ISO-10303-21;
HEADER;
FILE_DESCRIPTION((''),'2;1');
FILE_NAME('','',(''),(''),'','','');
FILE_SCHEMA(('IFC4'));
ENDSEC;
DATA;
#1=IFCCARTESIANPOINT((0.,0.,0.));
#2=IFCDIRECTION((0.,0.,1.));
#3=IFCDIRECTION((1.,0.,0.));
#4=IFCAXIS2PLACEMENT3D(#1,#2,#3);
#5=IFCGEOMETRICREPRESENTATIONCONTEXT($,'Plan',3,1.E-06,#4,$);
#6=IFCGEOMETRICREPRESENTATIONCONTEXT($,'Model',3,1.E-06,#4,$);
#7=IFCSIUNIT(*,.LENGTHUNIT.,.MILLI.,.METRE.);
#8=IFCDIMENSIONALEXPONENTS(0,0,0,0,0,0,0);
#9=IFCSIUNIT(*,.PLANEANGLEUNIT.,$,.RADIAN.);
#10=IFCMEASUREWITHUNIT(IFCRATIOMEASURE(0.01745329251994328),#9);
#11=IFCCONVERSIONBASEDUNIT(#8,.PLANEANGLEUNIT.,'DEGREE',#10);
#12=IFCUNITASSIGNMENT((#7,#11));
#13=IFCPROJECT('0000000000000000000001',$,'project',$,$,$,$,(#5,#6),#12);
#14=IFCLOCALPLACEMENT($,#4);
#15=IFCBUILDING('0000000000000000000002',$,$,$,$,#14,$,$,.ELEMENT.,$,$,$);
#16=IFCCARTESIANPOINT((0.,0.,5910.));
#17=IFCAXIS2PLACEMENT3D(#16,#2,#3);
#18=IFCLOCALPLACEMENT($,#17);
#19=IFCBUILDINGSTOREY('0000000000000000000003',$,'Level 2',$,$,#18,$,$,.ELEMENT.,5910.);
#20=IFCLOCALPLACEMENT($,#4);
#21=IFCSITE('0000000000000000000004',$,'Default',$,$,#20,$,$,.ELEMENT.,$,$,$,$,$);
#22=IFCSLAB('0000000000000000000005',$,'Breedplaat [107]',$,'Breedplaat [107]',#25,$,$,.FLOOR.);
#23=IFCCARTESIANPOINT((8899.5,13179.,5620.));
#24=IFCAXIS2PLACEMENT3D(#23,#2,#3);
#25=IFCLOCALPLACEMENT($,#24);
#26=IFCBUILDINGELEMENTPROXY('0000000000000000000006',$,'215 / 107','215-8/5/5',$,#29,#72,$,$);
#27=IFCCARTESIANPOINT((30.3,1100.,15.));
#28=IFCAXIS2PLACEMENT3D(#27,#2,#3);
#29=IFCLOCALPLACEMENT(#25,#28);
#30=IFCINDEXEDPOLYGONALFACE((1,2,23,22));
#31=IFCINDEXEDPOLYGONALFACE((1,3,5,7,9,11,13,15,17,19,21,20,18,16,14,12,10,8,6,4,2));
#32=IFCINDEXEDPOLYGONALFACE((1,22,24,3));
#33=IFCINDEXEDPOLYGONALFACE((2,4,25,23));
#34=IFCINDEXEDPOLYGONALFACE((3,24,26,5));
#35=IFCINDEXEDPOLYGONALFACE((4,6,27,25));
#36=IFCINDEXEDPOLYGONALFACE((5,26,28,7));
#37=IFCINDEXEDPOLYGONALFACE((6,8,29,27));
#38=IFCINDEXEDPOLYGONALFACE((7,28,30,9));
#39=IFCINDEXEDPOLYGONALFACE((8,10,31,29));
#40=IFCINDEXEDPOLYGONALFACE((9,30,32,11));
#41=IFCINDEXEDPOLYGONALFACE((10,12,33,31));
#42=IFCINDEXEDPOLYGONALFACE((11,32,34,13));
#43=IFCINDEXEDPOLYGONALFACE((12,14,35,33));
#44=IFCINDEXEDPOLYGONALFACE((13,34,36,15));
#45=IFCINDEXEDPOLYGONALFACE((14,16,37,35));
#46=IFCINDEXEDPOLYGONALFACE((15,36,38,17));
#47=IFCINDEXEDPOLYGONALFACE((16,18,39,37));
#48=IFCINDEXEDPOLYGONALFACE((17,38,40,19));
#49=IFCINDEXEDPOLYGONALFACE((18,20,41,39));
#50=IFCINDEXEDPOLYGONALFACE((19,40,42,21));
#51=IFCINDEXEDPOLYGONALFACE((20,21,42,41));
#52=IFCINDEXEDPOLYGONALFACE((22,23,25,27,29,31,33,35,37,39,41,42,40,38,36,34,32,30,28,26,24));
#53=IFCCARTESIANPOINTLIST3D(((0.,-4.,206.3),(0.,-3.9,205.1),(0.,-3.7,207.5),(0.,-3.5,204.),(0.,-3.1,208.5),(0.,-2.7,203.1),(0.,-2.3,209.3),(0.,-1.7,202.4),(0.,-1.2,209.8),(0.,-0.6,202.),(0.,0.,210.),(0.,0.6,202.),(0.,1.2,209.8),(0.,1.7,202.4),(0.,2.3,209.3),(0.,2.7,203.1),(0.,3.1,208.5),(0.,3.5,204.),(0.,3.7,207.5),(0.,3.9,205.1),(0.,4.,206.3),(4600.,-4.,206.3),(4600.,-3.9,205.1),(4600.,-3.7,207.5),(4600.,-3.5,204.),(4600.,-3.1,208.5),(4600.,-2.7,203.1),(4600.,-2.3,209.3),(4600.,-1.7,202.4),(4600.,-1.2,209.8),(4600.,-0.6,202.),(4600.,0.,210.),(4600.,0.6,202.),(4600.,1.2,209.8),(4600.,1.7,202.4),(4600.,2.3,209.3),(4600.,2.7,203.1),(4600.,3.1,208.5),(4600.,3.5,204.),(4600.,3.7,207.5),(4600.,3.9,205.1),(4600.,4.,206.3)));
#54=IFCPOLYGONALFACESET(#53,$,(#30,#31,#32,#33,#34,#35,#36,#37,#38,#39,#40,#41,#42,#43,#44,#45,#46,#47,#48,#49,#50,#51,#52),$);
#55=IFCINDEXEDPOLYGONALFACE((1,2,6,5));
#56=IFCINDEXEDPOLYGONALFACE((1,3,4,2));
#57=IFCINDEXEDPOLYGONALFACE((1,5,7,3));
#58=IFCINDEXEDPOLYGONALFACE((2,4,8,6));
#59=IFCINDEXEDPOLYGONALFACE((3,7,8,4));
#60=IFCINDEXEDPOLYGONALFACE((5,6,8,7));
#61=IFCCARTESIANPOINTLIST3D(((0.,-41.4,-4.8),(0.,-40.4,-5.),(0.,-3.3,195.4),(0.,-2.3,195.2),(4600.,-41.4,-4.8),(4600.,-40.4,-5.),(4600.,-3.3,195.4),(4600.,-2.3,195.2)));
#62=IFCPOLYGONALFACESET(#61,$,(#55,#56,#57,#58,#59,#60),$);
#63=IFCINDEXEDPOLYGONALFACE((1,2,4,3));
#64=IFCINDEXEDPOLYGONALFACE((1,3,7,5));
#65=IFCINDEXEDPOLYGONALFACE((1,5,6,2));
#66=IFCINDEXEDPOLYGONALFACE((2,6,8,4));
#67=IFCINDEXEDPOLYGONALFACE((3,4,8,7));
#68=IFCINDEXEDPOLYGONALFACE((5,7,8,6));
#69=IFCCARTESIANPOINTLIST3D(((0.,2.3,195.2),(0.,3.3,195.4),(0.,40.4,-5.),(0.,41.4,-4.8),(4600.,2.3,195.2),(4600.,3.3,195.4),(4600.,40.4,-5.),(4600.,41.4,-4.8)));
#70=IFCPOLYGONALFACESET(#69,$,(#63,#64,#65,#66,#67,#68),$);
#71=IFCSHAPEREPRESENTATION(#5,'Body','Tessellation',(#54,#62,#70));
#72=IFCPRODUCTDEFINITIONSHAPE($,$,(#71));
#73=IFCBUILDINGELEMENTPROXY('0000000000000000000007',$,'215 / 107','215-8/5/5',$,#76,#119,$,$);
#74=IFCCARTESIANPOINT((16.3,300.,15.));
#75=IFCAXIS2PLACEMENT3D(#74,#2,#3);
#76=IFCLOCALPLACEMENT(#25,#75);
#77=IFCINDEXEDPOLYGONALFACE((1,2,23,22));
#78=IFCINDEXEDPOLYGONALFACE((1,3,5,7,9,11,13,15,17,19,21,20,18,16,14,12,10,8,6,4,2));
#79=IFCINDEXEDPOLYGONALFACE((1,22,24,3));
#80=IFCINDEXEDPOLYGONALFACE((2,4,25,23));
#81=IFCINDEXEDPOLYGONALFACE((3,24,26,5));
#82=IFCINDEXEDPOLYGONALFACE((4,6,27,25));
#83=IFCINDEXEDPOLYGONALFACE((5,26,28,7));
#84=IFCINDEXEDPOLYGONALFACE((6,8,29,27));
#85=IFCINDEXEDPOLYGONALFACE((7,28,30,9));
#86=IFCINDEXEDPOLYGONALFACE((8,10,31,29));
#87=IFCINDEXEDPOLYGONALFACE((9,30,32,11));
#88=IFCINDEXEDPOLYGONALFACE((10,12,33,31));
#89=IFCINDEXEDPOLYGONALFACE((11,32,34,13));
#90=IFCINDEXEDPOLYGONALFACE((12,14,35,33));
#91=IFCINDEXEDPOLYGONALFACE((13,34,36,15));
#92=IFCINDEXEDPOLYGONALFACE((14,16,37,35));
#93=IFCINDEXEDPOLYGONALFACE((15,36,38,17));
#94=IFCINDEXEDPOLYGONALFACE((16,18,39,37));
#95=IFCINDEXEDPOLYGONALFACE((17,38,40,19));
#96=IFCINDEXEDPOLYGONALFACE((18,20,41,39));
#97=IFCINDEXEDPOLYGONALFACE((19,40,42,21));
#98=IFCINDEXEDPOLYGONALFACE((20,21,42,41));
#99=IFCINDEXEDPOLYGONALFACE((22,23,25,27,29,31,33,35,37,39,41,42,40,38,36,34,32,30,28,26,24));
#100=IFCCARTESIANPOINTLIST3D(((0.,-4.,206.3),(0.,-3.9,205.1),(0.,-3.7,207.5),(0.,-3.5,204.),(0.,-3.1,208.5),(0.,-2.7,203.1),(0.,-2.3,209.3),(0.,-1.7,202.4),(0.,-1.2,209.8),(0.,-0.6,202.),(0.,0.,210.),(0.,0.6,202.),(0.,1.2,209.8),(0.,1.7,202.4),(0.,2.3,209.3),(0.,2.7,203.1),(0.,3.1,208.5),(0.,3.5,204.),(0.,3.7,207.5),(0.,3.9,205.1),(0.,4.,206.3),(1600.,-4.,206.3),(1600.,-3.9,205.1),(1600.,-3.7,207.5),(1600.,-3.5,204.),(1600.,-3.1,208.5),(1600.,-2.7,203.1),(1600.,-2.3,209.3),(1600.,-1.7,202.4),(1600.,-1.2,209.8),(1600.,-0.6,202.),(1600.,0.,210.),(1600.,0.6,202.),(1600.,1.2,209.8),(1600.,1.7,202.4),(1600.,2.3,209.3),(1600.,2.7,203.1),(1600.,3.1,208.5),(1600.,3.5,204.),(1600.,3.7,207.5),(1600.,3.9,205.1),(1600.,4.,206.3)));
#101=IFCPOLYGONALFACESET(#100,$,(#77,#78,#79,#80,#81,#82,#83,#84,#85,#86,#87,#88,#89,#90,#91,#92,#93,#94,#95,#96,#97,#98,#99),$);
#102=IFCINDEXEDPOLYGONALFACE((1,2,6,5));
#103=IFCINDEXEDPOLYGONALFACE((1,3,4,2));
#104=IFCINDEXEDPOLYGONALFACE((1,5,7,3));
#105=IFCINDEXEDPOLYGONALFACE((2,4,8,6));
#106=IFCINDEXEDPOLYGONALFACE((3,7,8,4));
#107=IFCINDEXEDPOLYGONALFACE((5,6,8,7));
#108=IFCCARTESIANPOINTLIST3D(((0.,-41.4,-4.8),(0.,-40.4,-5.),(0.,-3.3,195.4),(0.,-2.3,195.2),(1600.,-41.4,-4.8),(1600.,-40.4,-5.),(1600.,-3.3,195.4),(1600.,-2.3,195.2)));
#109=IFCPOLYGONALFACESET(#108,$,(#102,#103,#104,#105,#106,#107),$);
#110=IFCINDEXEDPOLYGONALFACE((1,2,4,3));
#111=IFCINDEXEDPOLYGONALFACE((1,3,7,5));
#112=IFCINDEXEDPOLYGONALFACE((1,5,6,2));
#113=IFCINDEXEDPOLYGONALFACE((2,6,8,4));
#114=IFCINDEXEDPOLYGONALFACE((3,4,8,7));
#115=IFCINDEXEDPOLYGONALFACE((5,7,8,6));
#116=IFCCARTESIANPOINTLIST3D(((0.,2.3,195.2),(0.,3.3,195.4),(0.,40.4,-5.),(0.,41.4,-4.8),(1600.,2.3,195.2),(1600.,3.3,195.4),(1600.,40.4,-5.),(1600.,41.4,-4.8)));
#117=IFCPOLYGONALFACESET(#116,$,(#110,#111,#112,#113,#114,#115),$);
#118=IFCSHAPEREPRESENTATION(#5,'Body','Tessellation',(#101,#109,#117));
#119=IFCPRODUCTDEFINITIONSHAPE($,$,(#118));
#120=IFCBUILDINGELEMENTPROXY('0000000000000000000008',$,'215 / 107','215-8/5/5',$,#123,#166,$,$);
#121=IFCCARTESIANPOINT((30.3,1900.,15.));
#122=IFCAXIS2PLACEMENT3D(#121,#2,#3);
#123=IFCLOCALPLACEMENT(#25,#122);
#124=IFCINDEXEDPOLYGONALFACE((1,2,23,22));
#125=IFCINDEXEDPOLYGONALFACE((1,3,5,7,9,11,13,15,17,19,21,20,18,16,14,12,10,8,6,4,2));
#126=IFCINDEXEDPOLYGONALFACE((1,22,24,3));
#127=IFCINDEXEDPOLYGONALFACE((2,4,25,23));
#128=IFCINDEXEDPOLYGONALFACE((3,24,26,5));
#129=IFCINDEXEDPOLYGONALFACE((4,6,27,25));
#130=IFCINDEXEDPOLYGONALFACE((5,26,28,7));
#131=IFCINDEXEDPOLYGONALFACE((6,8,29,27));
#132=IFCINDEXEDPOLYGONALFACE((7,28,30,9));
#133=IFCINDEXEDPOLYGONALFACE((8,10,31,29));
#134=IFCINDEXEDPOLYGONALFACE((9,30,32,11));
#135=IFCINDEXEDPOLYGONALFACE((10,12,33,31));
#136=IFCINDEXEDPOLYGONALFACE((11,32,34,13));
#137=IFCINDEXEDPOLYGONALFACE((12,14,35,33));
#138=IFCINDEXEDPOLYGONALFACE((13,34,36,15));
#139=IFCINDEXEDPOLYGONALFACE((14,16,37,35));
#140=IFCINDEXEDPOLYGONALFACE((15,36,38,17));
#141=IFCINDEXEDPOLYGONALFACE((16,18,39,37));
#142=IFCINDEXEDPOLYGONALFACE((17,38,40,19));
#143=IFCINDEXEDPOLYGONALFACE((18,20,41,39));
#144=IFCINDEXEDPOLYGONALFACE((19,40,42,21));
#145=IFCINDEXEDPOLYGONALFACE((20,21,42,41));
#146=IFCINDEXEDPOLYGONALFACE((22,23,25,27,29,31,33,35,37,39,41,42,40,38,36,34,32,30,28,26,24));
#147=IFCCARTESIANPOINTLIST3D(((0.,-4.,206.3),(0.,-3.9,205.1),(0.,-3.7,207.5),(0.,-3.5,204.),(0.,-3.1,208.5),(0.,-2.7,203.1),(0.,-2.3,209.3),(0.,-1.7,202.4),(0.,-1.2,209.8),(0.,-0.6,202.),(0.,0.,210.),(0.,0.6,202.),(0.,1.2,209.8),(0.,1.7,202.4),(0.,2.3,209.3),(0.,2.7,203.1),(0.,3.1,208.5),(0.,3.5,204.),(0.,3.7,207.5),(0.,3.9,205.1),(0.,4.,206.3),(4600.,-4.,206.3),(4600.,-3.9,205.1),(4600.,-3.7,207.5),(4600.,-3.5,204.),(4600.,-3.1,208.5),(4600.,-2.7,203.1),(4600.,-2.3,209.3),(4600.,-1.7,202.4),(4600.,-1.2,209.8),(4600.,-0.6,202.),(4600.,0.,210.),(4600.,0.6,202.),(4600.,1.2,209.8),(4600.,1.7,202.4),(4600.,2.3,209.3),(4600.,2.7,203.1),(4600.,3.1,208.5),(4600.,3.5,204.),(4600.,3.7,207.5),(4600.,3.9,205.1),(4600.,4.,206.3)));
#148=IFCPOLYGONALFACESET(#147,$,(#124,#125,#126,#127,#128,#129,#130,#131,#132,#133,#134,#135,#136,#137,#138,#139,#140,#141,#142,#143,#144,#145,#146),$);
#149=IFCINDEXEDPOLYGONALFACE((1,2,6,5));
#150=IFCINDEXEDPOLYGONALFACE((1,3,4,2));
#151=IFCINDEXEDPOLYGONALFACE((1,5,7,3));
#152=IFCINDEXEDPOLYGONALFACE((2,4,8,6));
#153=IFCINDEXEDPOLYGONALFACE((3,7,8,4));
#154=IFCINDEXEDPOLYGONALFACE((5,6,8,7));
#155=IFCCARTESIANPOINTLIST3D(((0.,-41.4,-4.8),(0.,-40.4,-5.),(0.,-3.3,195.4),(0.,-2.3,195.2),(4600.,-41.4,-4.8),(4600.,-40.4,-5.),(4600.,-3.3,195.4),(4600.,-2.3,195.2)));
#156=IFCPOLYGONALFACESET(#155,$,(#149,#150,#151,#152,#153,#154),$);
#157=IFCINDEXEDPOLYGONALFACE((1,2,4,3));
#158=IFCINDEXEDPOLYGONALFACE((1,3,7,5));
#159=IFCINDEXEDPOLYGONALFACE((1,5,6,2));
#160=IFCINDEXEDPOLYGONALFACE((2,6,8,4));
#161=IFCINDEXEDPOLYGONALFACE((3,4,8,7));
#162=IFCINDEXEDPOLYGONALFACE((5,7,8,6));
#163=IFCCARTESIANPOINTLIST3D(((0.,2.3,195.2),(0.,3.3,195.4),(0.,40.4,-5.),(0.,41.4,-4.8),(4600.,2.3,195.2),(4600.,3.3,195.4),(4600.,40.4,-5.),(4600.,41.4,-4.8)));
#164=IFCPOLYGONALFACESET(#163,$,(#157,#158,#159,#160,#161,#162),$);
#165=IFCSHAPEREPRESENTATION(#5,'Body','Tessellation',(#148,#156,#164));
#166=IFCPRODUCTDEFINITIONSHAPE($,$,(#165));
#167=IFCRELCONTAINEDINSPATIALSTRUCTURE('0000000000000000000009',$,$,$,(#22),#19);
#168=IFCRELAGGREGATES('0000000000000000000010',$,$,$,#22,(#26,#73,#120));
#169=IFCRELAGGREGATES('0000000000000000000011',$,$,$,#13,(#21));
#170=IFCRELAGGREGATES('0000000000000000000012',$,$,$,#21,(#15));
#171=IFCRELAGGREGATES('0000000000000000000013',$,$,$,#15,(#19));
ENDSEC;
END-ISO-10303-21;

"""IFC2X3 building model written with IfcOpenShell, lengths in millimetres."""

from ifc_helpers import new_model, entity, si_unit, converted_unit, frame, origin_with_axes, origin_2d_with_axis, place, context, project, spatial, rectangle, circle, extrude, element, aggregate, save


model = new_model("IFC2X3")

# Units and contexts
plan_context = context("Plan", 3, precision=1e-06, world=origin_with_axes())
model_context = context("Model", 3, precision=1e-06, world=origin_with_axes())
ifc_project = project(units=[si_unit("LENGTHUNIT", "METRE", prefix="MILLI"), converted_unit("PLANEANGLEUNIT", "DEGREE", entity("IfcRatioMeasure", 0.01745329251994328), si_unit("PLANEANGLEUNIT", "RADIAN"), dimensions=[0, 0, 0, 0, 0, 0, 0])], contexts=[plan_context, model_context])

# Site, building, storey
site_placement = place(None, origin_with_axes())
site = spatial("IfcSite", under=ifc_project, at=site_placement, Name="Default", CompositionType="ELEMENT")
building_placement = place(None, origin_with_axes())
building = spatial("IfcBuilding", under=site, at=building_placement, CompositionType="ELEMENT")
storey_placement = place(None, frame((0.0, 0.0, 5910.0), z_axis=(0.0, 0.0, 1.0), x_axis=(1.0, 0.0, 0.0)))
storey = spatial("IfcBuildingStorey", under=building, at=storey_placement, Name="Level 2", CompositionType="ELEMENT", Elevation=5910.0)

# Slab, building element proxies
slab_1_placement = place(None, frame((8899.5, 13179.0, 5620.0), z_axis=(0.0, 0.0, 1.0), x_axis=(1.0, 0.0, 0.0)))
slab_1 = element("IfcSlab", 1, at=slab_1_placement, inside=storey, Name="Breedplaat [107]", ObjectType="Breedplaat [107]", PredefinedType="FLOOR")
proxy_1_placement = place(slab_1_placement, frame((30.3, 1100.0, 15.0), z_axis=(0.0, 0.0, 1.0), x_axis=(1.0, 0.0, 0.0)))
proxy_1 = element("IfcBuildingElementProxy", 2, at=proxy_1_placement, Name="215 / 107", Description="215-8/5/5", context=plan_context, shape_type="SweptSolid", body=[
    extrude(circle(Radius=4.0, at=origin_2d_with_axis()), frame((0.0, 0.0, 206.0), z_axis=(1.0, 0.0, 0.0), x_axis=(0.0, 0.0, 1.0)), (0.0, 0.0, 1.0), 4600.0),
    extrude(rectangle(XDim=203.8, YDim=1.0, at=origin_2d_with_axis()), frame((0.0, -21.9, 95.2), z_axis=(1.0, 0.0, 0.0), x_axis=(0.0, 0.187112, 0.982339)), (0.0, 0.0, 1.0), 4600.0),
    extrude(rectangle(XDim=203.8, YDim=1.0, at=origin_2d_with_axis()), frame((0.0, 21.9, 95.2), z_axis=(1.0, 0.0, 0.0), x_axis=(0.0, -0.187112, 0.982339)), (0.0, 0.0, 1.0), 4600.0),
])
proxy_2_placement = place(slab_1_placement, frame((16.3, 300.0, 15.0), z_axis=(0.0, 0.0, 1.0), x_axis=(1.0, 0.0, 0.0)))
proxy_2 = element("IfcBuildingElementProxy", 3, at=proxy_2_placement, Name="215 / 107", Description="215-8/5/5", context=plan_context, shape_type="SweptSolid", body=[
    extrude(circle(Radius=4.0, at=origin_2d_with_axis()), frame((0.0, 0.0, 206.0), z_axis=(1.0, 0.0, 0.0), x_axis=(0.0, 0.0, 1.0)), (0.0, 0.0, 1.0), 1600.0),
    extrude(rectangle(XDim=203.8, YDim=1.0, at=origin_2d_with_axis()), frame((0.0, -21.9, 95.2), z_axis=(1.0, 0.0, 0.0), x_axis=(0.0, 0.187112, 0.982339)), (0.0, 0.0, 1.0), 1600.0),
    extrude(rectangle(XDim=203.8, YDim=1.0, at=origin_2d_with_axis()), frame((0.0, 21.9, 95.2), z_axis=(1.0, 0.0, 0.0), x_axis=(0.0, -0.187112, 0.982339)), (0.0, 0.0, 1.0), 1600.0),
])
proxy_3_placement = place(slab_1_placement, frame((30.3, 1900.0, 15.0), z_axis=(0.0, 0.0, 1.0), x_axis=(1.0, 0.0, 0.0)))
proxy_3 = element("IfcBuildingElementProxy", 4, at=proxy_3_placement, Name="215 / 107", Description="215-8/5/5", context=plan_context, shape_type="SweptSolid", body=[
    extrude(circle(Radius=4.0, at=origin_2d_with_axis()), frame((0.0, 0.0, 206.0), z_axis=(1.0, 0.0, 0.0), x_axis=(0.0, 0.0, 1.0)), (0.0, 0.0, 1.0), 4600.0),
    extrude(rectangle(XDim=203.8, YDim=1.0, at=origin_2d_with_axis()), frame((0.0, -21.9, 95.2), z_axis=(1.0, 0.0, 0.0), x_axis=(0.0, 0.187112, 0.982339)), (0.0, 0.0, 1.0), 4600.0),
    extrude(rectangle(XDim=203.8, YDim=1.0, at=origin_2d_with_axis()), frame((0.0, 21.9, 95.2), z_axis=(1.0, 0.0, 0.0), x_axis=(0.0, -0.187112, 0.982339)), (0.0, 0.0, 1.0), 4600.0),
])
aggregate(slab_1, [proxy_1, proxy_2, proxy_3])

save(model, "model.ifc")
